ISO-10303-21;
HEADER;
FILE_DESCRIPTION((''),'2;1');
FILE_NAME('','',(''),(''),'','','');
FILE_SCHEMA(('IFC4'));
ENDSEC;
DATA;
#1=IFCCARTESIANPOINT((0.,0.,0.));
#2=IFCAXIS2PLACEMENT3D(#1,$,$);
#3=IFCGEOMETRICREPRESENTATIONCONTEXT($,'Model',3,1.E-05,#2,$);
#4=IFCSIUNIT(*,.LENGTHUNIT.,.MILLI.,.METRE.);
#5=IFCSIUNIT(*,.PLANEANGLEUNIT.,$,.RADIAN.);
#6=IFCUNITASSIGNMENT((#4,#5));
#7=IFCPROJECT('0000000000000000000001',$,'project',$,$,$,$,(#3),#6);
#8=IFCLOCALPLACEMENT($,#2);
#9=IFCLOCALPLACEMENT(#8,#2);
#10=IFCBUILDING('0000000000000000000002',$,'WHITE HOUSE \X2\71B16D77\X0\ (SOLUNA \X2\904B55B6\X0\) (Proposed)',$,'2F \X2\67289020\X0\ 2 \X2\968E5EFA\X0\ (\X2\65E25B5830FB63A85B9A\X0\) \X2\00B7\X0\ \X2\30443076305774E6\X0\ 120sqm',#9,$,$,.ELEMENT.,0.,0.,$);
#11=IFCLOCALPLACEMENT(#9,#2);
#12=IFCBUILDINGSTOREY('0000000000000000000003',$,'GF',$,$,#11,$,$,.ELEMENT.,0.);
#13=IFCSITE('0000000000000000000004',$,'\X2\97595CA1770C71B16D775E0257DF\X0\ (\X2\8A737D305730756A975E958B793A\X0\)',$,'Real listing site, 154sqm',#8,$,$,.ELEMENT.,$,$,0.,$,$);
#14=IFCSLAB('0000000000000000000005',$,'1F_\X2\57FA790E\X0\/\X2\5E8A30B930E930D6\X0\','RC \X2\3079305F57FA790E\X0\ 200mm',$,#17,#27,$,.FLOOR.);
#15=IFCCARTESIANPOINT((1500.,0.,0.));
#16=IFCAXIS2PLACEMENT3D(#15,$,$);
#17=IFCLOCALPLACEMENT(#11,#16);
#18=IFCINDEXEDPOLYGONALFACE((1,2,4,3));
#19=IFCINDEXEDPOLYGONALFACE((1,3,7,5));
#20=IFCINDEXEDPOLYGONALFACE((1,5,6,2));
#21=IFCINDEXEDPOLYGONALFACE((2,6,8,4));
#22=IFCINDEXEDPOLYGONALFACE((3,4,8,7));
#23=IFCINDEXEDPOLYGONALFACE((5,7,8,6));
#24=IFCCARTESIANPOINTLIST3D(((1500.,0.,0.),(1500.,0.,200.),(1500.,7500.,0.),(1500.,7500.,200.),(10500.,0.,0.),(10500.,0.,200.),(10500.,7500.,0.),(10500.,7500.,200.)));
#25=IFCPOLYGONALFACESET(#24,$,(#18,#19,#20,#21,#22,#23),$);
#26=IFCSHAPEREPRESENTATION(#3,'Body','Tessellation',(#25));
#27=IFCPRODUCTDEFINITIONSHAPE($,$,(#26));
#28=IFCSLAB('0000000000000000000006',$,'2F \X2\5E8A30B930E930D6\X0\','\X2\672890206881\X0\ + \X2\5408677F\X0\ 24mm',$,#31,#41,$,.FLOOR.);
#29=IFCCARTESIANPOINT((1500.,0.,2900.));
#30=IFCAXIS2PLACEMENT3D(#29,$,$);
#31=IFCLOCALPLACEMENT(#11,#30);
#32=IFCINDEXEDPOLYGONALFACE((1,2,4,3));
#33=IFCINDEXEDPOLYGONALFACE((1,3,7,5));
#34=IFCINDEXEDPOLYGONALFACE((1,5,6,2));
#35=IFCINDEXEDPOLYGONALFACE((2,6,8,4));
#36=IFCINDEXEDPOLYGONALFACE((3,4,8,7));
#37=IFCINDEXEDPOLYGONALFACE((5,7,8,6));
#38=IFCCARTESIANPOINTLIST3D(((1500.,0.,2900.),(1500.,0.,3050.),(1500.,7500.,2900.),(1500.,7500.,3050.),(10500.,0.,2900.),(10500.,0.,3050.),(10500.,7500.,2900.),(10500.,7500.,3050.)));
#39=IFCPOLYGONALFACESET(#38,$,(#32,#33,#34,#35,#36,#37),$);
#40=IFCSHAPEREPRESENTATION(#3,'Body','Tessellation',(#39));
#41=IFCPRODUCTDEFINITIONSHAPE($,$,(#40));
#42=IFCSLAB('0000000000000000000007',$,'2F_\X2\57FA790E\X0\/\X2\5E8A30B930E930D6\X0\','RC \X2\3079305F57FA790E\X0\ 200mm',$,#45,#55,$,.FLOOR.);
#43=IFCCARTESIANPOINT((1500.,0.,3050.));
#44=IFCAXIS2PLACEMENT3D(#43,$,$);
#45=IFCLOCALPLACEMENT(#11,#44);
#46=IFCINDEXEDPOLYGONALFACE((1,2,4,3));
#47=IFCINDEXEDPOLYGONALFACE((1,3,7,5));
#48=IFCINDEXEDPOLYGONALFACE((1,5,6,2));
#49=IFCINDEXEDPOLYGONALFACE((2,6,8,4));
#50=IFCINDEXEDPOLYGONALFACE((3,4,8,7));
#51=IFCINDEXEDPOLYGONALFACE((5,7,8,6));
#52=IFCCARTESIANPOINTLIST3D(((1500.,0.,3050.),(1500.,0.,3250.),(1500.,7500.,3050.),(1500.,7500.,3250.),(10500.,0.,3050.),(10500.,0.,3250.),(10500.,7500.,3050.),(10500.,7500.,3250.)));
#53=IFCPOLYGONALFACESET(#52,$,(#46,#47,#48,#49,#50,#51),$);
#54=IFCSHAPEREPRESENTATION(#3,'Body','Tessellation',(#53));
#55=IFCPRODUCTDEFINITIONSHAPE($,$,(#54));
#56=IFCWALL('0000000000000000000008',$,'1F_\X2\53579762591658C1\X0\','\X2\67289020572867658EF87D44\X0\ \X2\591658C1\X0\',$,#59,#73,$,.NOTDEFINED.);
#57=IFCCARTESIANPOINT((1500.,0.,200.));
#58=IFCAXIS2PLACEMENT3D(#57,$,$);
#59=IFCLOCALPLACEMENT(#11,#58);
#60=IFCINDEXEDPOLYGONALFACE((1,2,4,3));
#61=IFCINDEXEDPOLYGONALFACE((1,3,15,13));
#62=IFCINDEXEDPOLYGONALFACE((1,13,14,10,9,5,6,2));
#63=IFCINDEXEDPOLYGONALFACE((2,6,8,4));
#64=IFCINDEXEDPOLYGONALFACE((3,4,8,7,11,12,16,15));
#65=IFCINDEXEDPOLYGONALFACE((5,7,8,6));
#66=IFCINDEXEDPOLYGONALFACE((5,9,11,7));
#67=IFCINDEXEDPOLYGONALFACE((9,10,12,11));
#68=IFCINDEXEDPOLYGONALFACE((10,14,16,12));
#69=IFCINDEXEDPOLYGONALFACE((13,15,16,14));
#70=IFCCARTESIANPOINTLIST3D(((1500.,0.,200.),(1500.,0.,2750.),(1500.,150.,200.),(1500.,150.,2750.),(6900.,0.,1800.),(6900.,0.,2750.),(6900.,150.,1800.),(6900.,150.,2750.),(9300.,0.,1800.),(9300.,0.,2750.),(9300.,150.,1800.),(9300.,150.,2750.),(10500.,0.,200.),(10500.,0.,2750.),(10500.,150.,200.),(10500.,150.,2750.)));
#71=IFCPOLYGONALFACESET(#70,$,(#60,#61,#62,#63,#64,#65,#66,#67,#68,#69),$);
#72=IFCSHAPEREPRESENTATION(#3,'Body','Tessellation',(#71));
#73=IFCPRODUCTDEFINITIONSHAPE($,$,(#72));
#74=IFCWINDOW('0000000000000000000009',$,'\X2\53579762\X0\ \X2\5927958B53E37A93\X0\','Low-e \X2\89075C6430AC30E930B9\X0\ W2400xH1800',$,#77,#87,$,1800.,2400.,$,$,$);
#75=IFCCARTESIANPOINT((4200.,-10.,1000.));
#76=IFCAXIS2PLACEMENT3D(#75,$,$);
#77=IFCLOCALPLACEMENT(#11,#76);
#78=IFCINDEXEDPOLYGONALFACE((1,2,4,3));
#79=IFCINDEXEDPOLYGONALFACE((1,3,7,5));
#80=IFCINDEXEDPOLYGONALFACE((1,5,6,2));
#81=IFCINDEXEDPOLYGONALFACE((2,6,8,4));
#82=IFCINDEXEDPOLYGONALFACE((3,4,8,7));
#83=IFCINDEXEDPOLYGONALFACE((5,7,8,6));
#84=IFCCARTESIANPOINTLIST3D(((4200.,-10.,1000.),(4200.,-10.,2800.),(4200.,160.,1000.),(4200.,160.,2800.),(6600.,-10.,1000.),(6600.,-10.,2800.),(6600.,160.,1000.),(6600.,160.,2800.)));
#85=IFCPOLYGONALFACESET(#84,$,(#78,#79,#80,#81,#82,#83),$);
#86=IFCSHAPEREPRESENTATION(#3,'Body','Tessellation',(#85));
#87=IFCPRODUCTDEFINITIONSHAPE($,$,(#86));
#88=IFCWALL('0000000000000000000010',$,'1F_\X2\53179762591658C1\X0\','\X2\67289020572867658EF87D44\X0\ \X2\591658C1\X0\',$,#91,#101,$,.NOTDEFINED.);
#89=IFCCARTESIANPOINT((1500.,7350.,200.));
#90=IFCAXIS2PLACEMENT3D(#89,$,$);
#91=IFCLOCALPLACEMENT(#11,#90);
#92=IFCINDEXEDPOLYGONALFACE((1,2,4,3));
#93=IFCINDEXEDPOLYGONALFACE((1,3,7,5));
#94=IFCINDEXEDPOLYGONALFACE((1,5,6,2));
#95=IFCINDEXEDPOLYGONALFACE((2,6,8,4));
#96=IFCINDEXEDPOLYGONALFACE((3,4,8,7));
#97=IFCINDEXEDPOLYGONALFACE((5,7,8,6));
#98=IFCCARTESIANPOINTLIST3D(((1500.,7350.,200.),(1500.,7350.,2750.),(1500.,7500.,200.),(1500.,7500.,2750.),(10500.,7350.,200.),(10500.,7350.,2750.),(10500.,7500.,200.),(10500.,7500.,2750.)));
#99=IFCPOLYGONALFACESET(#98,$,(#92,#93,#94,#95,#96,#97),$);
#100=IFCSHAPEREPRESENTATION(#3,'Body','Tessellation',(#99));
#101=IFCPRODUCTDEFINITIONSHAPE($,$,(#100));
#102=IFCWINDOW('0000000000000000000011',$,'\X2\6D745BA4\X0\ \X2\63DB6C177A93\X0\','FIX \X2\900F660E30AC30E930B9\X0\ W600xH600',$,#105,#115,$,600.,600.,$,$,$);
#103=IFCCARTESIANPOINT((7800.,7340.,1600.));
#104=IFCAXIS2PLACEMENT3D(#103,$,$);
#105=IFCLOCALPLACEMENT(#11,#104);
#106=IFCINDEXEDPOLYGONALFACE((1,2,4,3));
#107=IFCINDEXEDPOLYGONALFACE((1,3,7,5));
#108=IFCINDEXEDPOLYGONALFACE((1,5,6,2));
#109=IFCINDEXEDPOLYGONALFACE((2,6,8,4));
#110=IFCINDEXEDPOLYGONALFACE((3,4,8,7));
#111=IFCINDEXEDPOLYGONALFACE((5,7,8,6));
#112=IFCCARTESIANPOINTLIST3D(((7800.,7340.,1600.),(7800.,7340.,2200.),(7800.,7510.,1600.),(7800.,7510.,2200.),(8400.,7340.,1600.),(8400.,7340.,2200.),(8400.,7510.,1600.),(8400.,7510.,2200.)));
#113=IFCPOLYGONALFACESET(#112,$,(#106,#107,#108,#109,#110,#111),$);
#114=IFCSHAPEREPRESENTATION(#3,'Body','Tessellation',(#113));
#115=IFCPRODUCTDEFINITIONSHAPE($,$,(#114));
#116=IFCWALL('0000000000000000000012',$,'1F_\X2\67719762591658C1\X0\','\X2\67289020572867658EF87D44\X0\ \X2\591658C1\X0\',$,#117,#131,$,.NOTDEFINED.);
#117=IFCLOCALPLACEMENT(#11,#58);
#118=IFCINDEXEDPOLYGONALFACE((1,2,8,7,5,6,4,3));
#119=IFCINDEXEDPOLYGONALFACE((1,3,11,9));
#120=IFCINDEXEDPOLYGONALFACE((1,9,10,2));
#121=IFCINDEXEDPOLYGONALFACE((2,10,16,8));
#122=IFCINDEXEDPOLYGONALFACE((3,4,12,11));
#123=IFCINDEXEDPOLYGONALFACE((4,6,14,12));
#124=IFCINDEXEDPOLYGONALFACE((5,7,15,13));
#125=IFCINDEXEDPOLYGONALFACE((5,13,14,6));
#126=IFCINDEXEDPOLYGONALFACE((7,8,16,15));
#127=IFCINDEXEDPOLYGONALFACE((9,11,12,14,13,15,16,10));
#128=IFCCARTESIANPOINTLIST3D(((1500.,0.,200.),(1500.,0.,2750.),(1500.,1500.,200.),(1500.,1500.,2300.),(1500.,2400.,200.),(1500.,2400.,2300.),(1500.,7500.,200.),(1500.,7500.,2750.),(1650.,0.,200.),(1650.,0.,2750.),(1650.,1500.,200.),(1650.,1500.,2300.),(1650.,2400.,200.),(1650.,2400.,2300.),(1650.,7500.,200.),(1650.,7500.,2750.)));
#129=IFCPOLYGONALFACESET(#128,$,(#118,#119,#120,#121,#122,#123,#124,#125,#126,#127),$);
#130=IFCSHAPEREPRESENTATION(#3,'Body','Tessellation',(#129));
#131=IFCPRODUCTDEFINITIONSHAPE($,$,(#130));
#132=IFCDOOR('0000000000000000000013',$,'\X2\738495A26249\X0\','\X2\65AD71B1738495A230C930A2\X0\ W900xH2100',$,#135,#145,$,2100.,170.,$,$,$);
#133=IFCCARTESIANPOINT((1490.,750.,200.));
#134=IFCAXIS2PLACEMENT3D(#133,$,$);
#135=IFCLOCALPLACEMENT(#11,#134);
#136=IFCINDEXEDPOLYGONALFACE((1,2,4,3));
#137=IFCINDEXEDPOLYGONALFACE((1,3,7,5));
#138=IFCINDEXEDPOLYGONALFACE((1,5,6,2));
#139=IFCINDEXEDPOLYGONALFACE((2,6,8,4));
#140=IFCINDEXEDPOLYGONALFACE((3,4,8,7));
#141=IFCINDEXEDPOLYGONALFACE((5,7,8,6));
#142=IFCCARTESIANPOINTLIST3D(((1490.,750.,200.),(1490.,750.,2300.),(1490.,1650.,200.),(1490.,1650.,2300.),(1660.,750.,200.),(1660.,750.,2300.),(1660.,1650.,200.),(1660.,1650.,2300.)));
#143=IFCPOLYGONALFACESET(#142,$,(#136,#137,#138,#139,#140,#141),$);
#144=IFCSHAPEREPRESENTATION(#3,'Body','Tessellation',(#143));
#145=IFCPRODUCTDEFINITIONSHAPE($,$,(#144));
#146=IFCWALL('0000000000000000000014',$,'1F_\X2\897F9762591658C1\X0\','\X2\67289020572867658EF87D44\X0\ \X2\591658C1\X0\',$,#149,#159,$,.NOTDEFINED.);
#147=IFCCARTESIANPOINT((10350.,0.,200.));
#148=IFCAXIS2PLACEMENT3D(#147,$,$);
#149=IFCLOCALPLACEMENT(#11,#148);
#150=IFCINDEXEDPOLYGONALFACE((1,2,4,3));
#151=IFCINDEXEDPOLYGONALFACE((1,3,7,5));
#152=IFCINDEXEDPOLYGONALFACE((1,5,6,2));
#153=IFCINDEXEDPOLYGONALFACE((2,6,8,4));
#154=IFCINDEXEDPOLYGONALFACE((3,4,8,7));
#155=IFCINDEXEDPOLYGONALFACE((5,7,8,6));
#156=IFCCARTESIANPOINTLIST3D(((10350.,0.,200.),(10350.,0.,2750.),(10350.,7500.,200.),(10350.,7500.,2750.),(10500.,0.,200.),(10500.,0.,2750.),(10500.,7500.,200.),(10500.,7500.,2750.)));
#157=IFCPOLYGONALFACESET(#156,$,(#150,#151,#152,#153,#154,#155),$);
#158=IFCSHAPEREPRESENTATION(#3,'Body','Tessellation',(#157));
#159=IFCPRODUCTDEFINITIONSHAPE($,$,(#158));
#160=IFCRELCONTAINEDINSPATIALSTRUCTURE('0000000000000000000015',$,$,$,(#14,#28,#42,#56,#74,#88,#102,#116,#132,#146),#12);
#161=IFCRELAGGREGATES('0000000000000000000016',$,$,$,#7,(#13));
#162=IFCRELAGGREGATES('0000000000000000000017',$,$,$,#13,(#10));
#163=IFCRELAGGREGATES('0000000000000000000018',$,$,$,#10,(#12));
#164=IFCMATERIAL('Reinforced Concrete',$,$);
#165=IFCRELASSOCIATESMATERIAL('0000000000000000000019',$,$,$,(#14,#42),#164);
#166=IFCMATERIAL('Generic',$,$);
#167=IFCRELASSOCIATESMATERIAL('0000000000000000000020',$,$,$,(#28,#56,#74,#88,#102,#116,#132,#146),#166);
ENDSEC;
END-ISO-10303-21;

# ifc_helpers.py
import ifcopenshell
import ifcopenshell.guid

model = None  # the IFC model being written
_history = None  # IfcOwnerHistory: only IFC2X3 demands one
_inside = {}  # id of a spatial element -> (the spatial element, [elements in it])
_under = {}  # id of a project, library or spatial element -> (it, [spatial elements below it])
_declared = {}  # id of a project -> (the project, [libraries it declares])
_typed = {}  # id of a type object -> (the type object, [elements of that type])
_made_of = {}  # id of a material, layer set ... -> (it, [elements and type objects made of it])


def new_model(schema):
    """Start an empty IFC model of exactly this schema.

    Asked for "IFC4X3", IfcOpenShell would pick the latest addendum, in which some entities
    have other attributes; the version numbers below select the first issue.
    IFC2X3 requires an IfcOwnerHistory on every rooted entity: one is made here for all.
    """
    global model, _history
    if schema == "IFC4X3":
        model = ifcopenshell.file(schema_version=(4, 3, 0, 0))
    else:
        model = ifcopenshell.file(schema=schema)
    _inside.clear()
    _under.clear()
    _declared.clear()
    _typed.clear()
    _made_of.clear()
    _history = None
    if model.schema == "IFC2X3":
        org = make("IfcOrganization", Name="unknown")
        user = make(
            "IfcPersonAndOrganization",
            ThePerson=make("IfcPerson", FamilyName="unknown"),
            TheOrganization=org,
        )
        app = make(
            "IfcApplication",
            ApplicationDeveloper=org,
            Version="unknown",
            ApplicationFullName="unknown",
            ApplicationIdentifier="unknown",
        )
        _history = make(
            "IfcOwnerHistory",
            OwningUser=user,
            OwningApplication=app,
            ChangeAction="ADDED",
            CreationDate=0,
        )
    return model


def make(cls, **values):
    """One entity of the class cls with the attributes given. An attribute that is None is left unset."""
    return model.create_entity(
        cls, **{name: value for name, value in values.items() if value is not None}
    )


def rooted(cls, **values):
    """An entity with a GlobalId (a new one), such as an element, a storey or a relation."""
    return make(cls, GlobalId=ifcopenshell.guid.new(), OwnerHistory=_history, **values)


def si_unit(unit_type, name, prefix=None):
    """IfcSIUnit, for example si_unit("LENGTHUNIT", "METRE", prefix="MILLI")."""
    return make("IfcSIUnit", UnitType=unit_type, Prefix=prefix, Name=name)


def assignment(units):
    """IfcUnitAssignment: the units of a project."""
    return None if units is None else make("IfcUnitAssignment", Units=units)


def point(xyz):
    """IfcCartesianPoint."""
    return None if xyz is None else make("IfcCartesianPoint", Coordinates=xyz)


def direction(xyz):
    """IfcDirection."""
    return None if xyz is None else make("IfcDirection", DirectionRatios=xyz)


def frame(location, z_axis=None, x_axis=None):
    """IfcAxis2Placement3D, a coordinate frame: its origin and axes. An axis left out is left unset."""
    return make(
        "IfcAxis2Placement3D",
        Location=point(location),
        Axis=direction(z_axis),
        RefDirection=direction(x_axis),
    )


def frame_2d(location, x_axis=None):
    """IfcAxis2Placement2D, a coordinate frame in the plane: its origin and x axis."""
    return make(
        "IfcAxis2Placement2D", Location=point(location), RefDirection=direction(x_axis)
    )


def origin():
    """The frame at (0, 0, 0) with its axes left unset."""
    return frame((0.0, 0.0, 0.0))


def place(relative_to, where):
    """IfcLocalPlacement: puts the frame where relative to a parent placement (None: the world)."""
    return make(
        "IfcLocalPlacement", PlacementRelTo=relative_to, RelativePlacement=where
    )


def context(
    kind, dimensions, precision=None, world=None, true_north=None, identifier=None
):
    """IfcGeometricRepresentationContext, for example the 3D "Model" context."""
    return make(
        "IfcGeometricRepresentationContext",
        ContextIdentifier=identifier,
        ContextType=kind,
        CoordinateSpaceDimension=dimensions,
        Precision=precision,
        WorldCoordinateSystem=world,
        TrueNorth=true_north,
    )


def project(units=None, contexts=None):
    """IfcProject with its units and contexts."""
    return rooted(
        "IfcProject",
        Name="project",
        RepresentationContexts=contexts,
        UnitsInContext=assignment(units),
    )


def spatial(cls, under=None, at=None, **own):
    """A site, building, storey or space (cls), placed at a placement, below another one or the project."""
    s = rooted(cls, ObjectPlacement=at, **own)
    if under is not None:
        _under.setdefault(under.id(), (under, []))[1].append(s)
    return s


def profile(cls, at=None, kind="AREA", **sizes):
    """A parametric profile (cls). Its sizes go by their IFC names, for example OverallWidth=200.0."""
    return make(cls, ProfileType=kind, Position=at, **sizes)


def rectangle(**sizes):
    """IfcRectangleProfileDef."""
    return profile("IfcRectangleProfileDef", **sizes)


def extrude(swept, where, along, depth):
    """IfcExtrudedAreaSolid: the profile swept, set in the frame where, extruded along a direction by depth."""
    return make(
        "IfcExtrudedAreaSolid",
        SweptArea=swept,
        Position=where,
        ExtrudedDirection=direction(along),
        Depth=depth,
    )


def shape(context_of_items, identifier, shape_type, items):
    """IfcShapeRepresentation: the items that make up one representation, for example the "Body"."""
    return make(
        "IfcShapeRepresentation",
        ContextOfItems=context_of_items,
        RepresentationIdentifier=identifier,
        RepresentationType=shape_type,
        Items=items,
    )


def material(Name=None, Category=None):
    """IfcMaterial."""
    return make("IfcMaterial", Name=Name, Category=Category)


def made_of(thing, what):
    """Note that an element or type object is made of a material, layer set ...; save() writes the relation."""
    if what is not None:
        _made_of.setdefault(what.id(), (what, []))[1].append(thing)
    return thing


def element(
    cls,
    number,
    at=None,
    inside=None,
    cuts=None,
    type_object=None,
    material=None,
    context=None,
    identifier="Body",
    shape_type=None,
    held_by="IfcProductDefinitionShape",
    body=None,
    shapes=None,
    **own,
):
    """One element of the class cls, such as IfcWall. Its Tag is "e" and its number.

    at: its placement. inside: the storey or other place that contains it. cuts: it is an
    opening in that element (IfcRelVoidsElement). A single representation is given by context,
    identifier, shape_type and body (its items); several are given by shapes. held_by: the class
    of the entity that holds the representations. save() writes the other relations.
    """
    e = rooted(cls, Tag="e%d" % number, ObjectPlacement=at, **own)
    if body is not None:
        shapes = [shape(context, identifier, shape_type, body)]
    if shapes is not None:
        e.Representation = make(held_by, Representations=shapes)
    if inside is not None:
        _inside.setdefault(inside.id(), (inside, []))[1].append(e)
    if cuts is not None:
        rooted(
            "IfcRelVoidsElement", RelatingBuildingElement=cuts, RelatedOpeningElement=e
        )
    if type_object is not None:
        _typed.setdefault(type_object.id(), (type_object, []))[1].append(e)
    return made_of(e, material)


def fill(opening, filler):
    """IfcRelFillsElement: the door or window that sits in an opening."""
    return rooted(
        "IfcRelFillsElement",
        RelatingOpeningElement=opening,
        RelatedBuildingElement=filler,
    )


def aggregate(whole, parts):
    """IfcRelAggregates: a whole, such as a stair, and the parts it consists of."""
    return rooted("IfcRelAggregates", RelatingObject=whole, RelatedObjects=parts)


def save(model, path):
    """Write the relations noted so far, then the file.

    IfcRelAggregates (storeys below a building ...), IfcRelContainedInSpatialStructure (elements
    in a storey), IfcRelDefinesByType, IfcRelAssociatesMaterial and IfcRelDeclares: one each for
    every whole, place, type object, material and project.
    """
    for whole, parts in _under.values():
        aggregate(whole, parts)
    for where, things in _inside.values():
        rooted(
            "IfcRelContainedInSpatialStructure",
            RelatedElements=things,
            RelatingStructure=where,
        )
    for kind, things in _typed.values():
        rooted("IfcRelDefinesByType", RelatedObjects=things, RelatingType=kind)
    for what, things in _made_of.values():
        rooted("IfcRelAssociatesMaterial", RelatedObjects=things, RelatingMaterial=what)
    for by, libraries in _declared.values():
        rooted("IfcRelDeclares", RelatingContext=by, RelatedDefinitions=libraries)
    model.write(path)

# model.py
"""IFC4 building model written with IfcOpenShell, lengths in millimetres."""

from ifc_helpers import new_model, si_unit, frame, frame_2d, origin, place, context, project, spatial, rectangle, extrude, material, element, fill, save


model = new_model("IFC4")

# Units and contexts
model_context = context("Model", 3, precision=1e-05, world=origin())
ifc_project = project(units=[si_unit("LENGTHUNIT", "METRE", prefix="MILLI"), si_unit("PLANEANGLEUNIT", "RADIAN")], contexts=[model_context])

# Site, building, storey
site_placement = place(None, origin())
site = spatial("IfcSite", under=ifc_project, at=site_placement, Name="静岡県熱海市域 (詳細地番非開示)", ObjectType="Real listing site, 154sqm", CompositionType="ELEMENT", RefElevation=0.0)
building_placement = place(site_placement, origin())
building = spatial("IfcBuilding", under=site, at=building_placement, Name="WHITE HOUSE 熱海 (SOLUNA 運営) (Proposed)", ObjectType="2F 木造 2 階建 (既存・推定) · いぶし瓦 120sqm", CompositionType="ELEMENT", ElevationOfRefHeight=0.0, ElevationOfTerrain=0.0)
storey_placement = place(building_placement, origin())
storey = spatial("IfcBuildingStorey", under=building, at=storey_placement, Name="GF", CompositionType="ELEMENT", Elevation=0.0)

# Slabs
ifc_material_1 = material(Name="Reinforced Concrete")
slab_1_placement = place(storey_placement, frame((1500.0, 0.0, 0.0)))
element("IfcSlab", 1, at=slab_1_placement, inside=storey, material=ifc_material_1, Name="1F_基礎/床スラブ", Description="RC べた基礎 200mm", PredefinedType="FLOOR", context=model_context, shape_type="SweptSolid", body=[
    extrude(rectangle(XDim=9000.0, YDim=7500.0, at=frame_2d((4500.0, 3750.0))), frame((1500.0, 0.0, 0.0)), (0.0, 0.0, 1.0), 200.0),
])
ifc_material_2 = material(Name="Generic")
slab_2_placement = place(storey_placement, frame((1500.0, 0.0, 2900.0)))
element("IfcSlab", 2, at=slab_2_placement, inside=storey, material=ifc_material_2, Name="2F 床スラブ", Description="木造梁 + 合板 24mm", PredefinedType="FLOOR", context=model_context, shape_type="SweptSolid", body=[
    extrude(rectangle(XDim=9000.0, YDim=7500.0, at=frame_2d((4500.0, 3750.0))), frame((1500.0, 0.0, 2900.0)), (0.0, 0.0, 1.0), 150.0),
])
slab_3_placement = place(storey_placement, frame((1500.0, 0.0, 3050.0)))
element("IfcSlab", 3, at=slab_3_placement, inside=storey, material=ifc_material_1, Name="2F_基礎/床スラブ", Description="RC べた基礎 200mm", PredefinedType="FLOOR", context=model_context, shape_type="SweptSolid", body=[
    extrude(rectangle(XDim=9000.0, YDim=7500.0, at=frame_2d((4500.0, 3750.0))), frame((1500.0, 0.0, 3050.0)), (0.0, 0.0, 1.0), 200.0),
])

# Walls, openings, windows
wall_1_placement = place(storey_placement, frame((1500.0, 0.0, 200.0)))
wall_1 = element("IfcWall", 4, at=wall_1_placement, inside=storey, material=ifc_material_2, Name="1F_南面外壁", Description="木造在来軸組 外壁", PredefinedType="NOTDEFINED", context=model_context, shape_type="SweptSolid", body=[
    extrude(rectangle(XDim=9000.0, YDim=150.0, at=frame_2d((4500.0, 75.0))), frame((1500.0, 0.0, 200.0)), (0.0, 0.0, 1.0), 2550.0),
])
opening_1_placement = place(storey_placement, frame((4200.0, -10.0, 1000.0)))
opening_1 = element("IfcOpeningElement", 5, at=opening_1_placement, cuts=wall_1, PredefinedType="NOTDEFINED", context=model_context, shape_type="SweptSolid", body=[
    extrude(rectangle(XDim=2400.0, YDim=170.0, at=frame_2d((1200.0, 85.0))), frame((4200.0, -10.0, 1000.0)), (0.0, 0.0, 1.0), 1800.0),
])
window_1_placement = place(storey_placement, frame((4200.0, -10.0, 1000.0)))
window_1 = element("IfcWindow", 6, at=window_1_placement, inside=storey, material=ifc_material_2, Name="南面 大開口窓", Description="Low-e 複層ガラス W2400xH1800", OverallHeight=1800.0, OverallWidth=2400.0, context=model_context, shape_type="SweptSolid", body=[
    extrude(rectangle(XDim=2400.0, YDim=170.0, at=frame_2d((1200.0, 85.0))), frame((4200.0, -10.0, 1000.0)), (0.0, 0.0, 1.0), 1800.0),
])
fill(opening_1, window_1)
wall_2_placement = place(storey_placement, frame((1500.0, 7350.0, 200.0)))
wall_2 = element("IfcWall", 7, at=wall_2_placement, inside=storey, material=ifc_material_2, Name="1F_北面外壁", Description="木造在来軸組 外壁", PredefinedType="NOTDEFINED", context=model_context, shape_type="SweptSolid", body=[
    extrude(rectangle(XDim=9000.0, YDim=150.0, at=frame_2d((4500.0, 75.0))), frame((1500.0, 7350.0, 200.0)), (0.0, 0.0, 1.0), 2550.0),
])
opening_2_placement = place(storey_placement, frame((7800.0, 7340.0, 1600.0)))
opening_2 = element("IfcOpeningElement", 8, at=opening_2_placement, cuts=wall_2, PredefinedType="NOTDEFINED", context=model_context, shape_type="SweptSolid", body=[
    extrude(rectangle(XDim=600.0, YDim=170.0, at=frame_2d((300.0, 85.0))), frame((7800.0, 7340.0, 1600.0)), (0.0, 0.0, 1.0), 600.0),
])
window_2_placement = place(storey_placement, frame((7800.0, 7340.0, 1600.0)))
window_2 = element("IfcWindow", 9, at=window_2_placement, inside=storey, material=ifc_material_2, Name="浴室 換気窓", Description="FIX 透明ガラス W600xH600", OverallHeight=600.0, OverallWidth=600.0, context=model_context, shape_type="SweptSolid", body=[
    extrude(rectangle(XDim=600.0, YDim=170.0, at=frame_2d((300.0, 85.0))), frame((7800.0, 7340.0, 1600.0)), (0.0, 0.0, 1.0), 600.0),
])
fill(opening_2, window_2)

# Wall, opening, door
wall_3_placement = place(storey_placement, frame((1500.0, 0.0, 200.0)))
wall_3 = element("IfcWall", 10, at=wall_3_placement, inside=storey, material=ifc_material_2, Name="1F_東面外壁", Description="木造在来軸組 外壁", PredefinedType="NOTDEFINED", context=model_context, shape_type="SweptSolid", body=[
    extrude(rectangle(XDim=150.0, YDim=7500.0, at=frame_2d((75.0, 3750.0))), frame((1500.0, 0.0, 200.0)), (0.0, 0.0, 1.0), 2550.0),
])
opening_3_placement = place(storey_placement, frame((1490.0, 750.0, 200.0)))
opening_3 = element("IfcOpeningElement", 11, at=opening_3_placement, cuts=wall_3, PredefinedType="NOTDEFINED", context=model_context, shape_type="SweptSolid", body=[
    extrude(rectangle(XDim=170.0, YDim=900.0, at=frame_2d((85.0, 450.0))), frame((1490.0, 750.0, 200.0)), (0.0, 0.0, 1.0), 2100.0),
])
door_placement = place(storey_placement, frame((1490.0, 750.0, 200.0)))
door = element("IfcDoor", 12, at=door_placement, inside=storey, material=ifc_material_2, Name="玄関扉", Description="断熱玄関ドア W900xH2100", OverallHeight=2100.0, OverallWidth=170.0, context=model_context, shape_type="SweptSolid", body=[
    extrude(rectangle(XDim=170.0, YDim=900.0, at=frame_2d((85.0, 450.0))), frame((1490.0, 750.0, 200.0)), (0.0, 0.0, 1.0), 2100.0),
])
fill(opening_3, door)

# Wall
wall_4_placement = place(storey_placement, frame((10350.0, 0.0, 200.0)))
element("IfcWall", 13, at=wall_4_placement, inside=storey, material=ifc_material_2, Name="1F_西面外壁", Description="木造在来軸組 外壁", PredefinedType="NOTDEFINED", context=model_context, shape_type="SweptSolid", body=[
    extrude(rectangle(XDim=150.0, YDim=7500.0, at=frame_2d((75.0, 3750.0))), frame((10350.0, 0.0, 200.0)), (0.0, 0.0, 1.0), 2550.0),
])

save(model, "model.ifc")
